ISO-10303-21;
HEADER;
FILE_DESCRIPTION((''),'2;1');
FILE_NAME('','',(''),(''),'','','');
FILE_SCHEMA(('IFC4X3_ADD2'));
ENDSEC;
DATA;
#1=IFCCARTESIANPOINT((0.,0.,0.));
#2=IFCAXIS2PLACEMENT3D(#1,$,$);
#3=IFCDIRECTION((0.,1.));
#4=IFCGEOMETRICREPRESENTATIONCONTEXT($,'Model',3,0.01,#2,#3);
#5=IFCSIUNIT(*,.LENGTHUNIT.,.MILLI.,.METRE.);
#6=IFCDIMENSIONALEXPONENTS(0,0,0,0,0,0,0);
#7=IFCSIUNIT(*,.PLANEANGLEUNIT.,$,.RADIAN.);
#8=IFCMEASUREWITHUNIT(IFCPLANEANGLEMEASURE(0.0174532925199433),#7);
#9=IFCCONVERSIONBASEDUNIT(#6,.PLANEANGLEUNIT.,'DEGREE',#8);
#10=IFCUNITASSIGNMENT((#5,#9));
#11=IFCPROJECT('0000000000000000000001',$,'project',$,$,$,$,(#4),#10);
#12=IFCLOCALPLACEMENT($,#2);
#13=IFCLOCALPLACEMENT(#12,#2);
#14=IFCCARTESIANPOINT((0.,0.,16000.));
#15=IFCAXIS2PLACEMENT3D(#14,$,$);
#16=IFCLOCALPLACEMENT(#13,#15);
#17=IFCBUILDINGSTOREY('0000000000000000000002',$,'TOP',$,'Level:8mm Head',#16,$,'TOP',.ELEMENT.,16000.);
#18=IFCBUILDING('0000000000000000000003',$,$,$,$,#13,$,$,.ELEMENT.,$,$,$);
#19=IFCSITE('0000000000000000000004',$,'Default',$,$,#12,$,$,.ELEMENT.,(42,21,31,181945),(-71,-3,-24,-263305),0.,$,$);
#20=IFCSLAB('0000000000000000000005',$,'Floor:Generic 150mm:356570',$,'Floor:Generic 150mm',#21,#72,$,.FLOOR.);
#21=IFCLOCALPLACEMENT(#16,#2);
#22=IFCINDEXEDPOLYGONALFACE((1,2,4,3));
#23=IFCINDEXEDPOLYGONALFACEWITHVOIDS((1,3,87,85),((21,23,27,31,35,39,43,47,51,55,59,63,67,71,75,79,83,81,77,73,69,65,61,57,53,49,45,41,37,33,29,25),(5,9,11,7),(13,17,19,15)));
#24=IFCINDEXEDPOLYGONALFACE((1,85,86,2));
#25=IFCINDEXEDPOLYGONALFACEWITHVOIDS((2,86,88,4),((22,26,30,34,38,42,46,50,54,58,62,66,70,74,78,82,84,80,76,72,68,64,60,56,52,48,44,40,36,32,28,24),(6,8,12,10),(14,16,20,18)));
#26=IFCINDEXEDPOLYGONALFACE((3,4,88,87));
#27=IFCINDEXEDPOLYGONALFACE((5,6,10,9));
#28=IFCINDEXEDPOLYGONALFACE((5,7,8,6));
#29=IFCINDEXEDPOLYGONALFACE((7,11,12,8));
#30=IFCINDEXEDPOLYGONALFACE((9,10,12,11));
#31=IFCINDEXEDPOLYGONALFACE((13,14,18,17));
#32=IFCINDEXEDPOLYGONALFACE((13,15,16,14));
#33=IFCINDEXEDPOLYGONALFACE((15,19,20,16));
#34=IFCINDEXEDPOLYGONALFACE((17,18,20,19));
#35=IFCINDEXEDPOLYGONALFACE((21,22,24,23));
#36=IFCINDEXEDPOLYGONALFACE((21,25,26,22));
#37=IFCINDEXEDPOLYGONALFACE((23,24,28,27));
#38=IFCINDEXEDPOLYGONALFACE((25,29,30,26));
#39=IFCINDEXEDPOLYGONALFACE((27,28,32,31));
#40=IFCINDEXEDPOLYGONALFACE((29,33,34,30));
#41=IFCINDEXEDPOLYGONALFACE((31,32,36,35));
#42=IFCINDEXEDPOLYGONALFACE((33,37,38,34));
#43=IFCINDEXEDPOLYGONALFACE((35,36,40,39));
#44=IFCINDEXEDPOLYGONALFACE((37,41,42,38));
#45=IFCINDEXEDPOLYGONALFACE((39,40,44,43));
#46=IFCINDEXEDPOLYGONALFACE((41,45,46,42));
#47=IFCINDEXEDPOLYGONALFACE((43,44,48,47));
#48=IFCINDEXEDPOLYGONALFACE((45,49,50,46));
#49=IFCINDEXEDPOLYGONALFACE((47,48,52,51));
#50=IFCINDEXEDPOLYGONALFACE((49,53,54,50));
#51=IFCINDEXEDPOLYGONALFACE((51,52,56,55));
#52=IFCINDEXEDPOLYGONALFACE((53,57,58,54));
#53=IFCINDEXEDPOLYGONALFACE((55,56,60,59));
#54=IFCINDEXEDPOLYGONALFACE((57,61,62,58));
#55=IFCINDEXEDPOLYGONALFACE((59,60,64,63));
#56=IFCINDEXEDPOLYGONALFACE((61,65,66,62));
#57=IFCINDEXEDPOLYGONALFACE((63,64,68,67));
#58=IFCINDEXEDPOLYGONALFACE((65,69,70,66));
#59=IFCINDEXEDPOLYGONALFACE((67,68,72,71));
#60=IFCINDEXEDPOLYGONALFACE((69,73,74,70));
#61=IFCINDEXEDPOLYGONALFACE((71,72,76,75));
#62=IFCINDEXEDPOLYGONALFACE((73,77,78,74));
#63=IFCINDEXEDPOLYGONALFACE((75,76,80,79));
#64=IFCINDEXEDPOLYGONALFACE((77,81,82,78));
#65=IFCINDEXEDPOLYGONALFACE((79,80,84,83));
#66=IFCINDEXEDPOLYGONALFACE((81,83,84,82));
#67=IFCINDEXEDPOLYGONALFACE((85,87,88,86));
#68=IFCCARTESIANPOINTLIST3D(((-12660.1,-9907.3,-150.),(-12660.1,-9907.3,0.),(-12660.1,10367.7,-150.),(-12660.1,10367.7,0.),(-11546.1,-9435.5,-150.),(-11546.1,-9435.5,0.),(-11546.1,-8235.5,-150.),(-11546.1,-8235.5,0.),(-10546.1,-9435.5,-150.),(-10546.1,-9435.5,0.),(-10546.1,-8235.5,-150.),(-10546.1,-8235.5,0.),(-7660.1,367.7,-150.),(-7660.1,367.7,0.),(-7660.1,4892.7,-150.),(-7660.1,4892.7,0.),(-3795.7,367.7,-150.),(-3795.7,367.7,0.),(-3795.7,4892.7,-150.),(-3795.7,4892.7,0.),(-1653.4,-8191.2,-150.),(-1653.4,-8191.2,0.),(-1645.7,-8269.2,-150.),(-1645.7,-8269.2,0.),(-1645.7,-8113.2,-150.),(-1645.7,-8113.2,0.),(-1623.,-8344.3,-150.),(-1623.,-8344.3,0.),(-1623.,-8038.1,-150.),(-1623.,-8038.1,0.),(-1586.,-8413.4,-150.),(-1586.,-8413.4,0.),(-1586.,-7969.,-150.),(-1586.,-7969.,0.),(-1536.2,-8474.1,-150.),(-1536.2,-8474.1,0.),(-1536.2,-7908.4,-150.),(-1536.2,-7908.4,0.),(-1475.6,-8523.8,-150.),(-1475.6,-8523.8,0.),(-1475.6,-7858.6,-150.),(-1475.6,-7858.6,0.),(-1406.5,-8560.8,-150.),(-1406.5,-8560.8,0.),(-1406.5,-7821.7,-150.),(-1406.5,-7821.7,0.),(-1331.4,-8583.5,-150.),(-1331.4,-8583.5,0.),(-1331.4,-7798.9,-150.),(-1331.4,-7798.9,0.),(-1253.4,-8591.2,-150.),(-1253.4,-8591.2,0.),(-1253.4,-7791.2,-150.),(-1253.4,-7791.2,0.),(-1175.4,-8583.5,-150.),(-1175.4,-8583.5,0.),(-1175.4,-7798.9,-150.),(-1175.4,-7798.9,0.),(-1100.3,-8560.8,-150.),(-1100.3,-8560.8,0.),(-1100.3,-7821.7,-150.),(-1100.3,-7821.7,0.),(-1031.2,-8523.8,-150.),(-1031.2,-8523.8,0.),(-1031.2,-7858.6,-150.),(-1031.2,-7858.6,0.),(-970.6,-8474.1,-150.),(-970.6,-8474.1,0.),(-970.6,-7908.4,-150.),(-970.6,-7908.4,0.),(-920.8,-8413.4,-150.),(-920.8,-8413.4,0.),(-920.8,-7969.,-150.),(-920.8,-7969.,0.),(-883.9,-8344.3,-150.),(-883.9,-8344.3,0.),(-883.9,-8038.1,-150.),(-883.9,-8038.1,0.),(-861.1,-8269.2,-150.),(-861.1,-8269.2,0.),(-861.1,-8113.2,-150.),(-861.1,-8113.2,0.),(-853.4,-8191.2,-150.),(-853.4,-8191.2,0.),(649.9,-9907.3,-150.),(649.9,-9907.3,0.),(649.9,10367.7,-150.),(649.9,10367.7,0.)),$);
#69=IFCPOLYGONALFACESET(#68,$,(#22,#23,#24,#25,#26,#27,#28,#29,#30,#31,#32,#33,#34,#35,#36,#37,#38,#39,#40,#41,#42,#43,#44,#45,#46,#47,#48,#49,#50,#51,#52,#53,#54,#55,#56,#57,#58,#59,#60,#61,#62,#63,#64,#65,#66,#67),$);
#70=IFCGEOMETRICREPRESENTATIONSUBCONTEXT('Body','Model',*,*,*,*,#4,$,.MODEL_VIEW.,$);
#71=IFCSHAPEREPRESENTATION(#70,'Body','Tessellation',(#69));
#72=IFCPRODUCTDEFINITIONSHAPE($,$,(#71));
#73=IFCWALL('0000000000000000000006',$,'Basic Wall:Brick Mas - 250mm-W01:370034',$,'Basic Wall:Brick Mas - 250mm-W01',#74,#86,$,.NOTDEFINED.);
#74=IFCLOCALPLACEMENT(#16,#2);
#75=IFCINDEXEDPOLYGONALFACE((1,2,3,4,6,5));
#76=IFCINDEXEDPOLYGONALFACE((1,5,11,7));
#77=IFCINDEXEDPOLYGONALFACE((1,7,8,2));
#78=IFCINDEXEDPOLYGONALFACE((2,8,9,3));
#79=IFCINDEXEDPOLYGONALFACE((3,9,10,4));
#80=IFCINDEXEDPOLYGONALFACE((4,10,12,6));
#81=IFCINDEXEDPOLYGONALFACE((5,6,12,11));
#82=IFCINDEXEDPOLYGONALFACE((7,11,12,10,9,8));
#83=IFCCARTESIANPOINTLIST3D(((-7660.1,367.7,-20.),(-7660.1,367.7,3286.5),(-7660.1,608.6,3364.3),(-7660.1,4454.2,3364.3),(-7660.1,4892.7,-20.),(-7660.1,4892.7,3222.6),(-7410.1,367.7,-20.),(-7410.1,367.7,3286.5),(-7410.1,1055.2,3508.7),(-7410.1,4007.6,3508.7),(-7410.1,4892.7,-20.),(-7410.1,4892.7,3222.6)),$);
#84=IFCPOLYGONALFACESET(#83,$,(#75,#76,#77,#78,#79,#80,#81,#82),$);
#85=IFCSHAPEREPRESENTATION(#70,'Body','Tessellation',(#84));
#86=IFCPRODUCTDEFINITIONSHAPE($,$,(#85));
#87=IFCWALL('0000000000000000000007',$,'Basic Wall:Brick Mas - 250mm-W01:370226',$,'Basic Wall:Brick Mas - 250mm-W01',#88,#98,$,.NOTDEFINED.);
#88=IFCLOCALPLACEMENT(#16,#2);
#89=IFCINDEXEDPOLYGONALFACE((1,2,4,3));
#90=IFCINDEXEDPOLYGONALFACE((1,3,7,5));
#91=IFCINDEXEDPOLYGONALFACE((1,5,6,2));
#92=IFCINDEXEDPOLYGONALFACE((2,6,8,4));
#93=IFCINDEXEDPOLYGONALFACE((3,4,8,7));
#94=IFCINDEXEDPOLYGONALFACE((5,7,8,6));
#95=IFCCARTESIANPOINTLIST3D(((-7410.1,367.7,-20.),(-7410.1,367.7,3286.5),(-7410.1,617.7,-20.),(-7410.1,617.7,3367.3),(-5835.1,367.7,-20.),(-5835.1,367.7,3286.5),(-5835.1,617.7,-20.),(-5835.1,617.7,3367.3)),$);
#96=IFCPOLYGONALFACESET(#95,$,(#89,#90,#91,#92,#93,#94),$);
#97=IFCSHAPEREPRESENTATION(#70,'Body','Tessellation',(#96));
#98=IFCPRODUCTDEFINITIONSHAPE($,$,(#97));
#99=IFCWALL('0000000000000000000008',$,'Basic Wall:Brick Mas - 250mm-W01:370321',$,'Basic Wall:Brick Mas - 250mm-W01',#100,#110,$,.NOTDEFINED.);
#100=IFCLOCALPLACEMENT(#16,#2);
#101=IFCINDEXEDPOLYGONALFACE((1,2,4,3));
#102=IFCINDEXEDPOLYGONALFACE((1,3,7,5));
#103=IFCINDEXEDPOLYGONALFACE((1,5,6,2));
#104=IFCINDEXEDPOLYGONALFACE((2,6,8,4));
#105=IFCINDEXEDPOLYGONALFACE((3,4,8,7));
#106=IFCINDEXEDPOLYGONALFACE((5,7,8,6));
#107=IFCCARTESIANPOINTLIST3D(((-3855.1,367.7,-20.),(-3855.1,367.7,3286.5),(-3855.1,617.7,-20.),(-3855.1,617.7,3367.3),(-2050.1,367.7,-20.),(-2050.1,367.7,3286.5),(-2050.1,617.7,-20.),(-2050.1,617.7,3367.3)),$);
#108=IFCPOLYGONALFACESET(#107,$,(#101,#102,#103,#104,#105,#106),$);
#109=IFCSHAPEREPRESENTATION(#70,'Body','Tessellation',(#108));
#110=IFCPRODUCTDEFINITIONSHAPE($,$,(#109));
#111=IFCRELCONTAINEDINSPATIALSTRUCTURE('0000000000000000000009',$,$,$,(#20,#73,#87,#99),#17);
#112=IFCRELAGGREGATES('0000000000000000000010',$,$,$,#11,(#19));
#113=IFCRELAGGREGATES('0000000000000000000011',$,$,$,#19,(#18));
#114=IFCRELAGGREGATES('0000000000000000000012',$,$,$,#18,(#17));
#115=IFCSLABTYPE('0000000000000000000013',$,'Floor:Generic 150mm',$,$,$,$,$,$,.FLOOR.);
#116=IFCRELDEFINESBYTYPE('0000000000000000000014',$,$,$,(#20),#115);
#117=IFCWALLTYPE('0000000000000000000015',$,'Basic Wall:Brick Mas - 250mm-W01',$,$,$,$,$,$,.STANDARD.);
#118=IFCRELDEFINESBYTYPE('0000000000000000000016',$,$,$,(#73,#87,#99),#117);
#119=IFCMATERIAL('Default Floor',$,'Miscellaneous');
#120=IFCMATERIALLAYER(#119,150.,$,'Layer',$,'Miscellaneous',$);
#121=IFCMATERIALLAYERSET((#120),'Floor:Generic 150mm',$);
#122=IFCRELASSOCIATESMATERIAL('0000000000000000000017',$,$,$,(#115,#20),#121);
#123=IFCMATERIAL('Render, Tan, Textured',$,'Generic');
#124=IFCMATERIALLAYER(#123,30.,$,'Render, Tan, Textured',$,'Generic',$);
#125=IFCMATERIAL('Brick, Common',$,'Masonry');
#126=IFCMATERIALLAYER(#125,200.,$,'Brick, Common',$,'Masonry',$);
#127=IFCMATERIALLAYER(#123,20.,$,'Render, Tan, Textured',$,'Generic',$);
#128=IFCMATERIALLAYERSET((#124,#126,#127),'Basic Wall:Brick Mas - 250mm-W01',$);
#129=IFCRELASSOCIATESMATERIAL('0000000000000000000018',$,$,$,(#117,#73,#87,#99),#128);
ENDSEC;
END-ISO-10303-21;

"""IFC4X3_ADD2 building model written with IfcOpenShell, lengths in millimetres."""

from ifc_helpers import new_model, entity, si_unit, converted_unit, direction, frame, frame_2d, origin, place, context, subcontext, project, spatial, polyline, rectangle, circle, extrude, clip, bounded_halfspace, material, layer, layer_set, layer_usage, type_object, element, save


model = new_model("IFC4X3_ADD2")

# Units and contexts
model_context = context("Model", 3, precision=0.01, world=origin(), true_north=direction((0.0, 1.0)))
body_context = subcontext(model_context, "Body", "Model", "MODEL_VIEW")
ifc_project = project(units=[si_unit("LENGTHUNIT", "METRE", prefix="MILLI"), converted_unit("PLANEANGLEUNIT", "DEGREE", entity("IfcPlaneAngleMeasure", 0.0174532925199433), si_unit("PLANEANGLEUNIT", "RADIAN"), dimensions=[0, 0, 0, 0, 0, 0, 0])], contexts=[model_context])

# Site, building, storey
site_placement = place(None, origin())
site = spatial("IfcSite", under=ifc_project, at=site_placement, Name="Default", CompositionType="ELEMENT", RefLatitude=(42, 21, 31, 181945), RefLongitude=(-71, -3, -24, -263305), RefElevation=0.0)
building_placement = place(site_placement, origin())
building = spatial("IfcBuilding", under=site, at=building_placement, CompositionType="ELEMENT")
storey_placement = place(building_placement, frame((0.0, 0.0, 16000.0)))
storey = spatial("IfcBuildingStorey", under=building, at=storey_placement, Name="TOP", ObjectType="Level:8mm Head", LongName="TOP", CompositionType="ELEMENT", Elevation=16000.0)

# Slab, openings
ifc_material_1 = material(Name="Default Floor", Category="Miscellaneous")
ifc_layer_1 = layer(ifc_material_1, 150.0, Name="Layer", Category="Miscellaneous")
ifc_layer_set_1 = layer_set([ifc_layer_1], Name="Floor:Generic 150mm")
ifc_layer_usage = layer_usage(ifc_layer_set_1, "AXIS3", "POSITIVE", 0.0)
slab_type = type_object("IfcSlabType", Name="Floor:Generic 150mm", PredefinedType="FLOOR", material=ifc_layer_set_1)
slab_placement = place(storey_placement, frame((-12660.1, -9907.3, -150.0)))
slab = element("IfcSlab", 1, at=slab_placement, inside=storey, type_object=slab_type, material=ifc_layer_usage, Name="Floor:Generic 150mm:356570", ObjectType="Floor:Generic 150mm", PredefinedType="FLOOR", context=body_context, shape_type="SweptSolid", body=[
    extrude(rectangle(XDim=20275.0, YDim=13310.0, at=frame_2d((0.0, 0.0), x_axis=(0.0, -1.0))), frame((6655.0, 10137.5, 150.0), z_axis=(0.0, 0.0, -1.0), x_axis=(-1.0, 0.0, 0.0)), (0.0, 0.0, 1.0), 150.0),
])
opening_1_placement = place(slab_placement, origin())
element("IfcOpeningElement", 2, at=opening_1_placement, cuts=slab, PredefinedType="OPENING", context=body_context, shape_type="SweptSolid", body=[
    extrude(circle(Radius=400.0, at=frame_2d((0.0, 0.0), x_axis=(1.0, 0.0))), frame((11406.7, 1716.1, 0.0)), (0.0, 0.0, 1.0), 150.0),
])
opening_2_placement = place(slab_placement, origin())
element("IfcOpeningElement", 3, at=opening_2_placement, cuts=slab, PredefinedType="OPENING", context=body_context, shape_type="SweptSolid", body=[
    extrude(rectangle(XDim=3864.4, YDim=4525.0, at=frame_2d((0.0, 0.0), x_axis=(1.0, 0.0))), frame((6932.2, 12537.5, 150.0), z_axis=(0.0, 0.0, -1.0), x_axis=(-1.0, 0.0, 0.0)), (0.0, 0.0, 1.0), 150.0),
])
opening_3_placement = place(slab_placement, origin())
element("IfcOpeningElement", 4, at=opening_3_placement, cuts=slab, PredefinedType="OPENING", context=body_context, shape_type="SweptSolid", body=[
    extrude(rectangle(XDim=1000.0, YDim=1200.0, at=frame_2d((0.0, 0.0), x_axis=(1.0, 0.0))), frame((1613.9, 1071.8, 150.0), z_axis=(0.0, 0.0, -1.0), x_axis=(-1.0, 0.0, 0.0)), (0.0, 0.0, 1.0), 150.0),
])

# Walls
ifc_material_2 = material(Name="Render, Tan, Textured", Category="Generic")
ifc_layer_2 = layer(ifc_material_2, 30.0, Name="Render, Tan, Textured", Category="Generic")
ifc_material_3 = material(Name="Brick, Common", Category="Masonry")
ifc_layer_3 = layer(ifc_material_3, 200.0, Name="Brick, Common", Category="Masonry")
ifc_layer_4 = layer(ifc_material_2, 20.0, Name="Render, Tan, Textured", Category="Generic")
ifc_layer_set_2 = layer_set([ifc_layer_2, ifc_layer_3, ifc_layer_4], Name="Basic Wall:Brick Mas - 250mm-W01")
wall_type = type_object("IfcWallType", Name="Basic Wall:Brick Mas - 250mm-W01", PredefinedType="STANDARD", material=ifc_layer_set_2)
wall_1_placement = place(storey_placement, frame((-7535.1, 367.7, -20.0), z_axis=(0.0, 0.0, 1.0), x_axis=(0.0, 1.0, 0.0)))
element("IfcWall", 5, at=wall_1_placement, inside=storey, type_object=wall_type, material=ifc_layer_set_2, Name="Basic Wall:Brick Mas - 250mm-W01:370034", ObjectType="Basic Wall:Brick Mas - 250mm-W01", PredefinedType="NOTDEFINED", context=body_context, shape_type="Clipping", body=[
    clip(clip(clip(extrude(rectangle(XDim=4525.0, YDim=250.0, at=frame_2d((2262.5, 0.0), x_axis=(-1.0, 0.0))), origin(), (0.0, 0.0, 1.0), 3528.7), bounded_halfspace(frame((3639.9, -125.0, 3528.7), z_axis=(0.307548, 0.0, 0.951533), x_axis=(0.0, 1.0, 0.0)), False, frame((3639.9, -125.0, 3528.7)), polyline([(0.0, 0.0), (885.1, 0.0), (885.1, 250.0), (446.6, 250.0), (0.0, 0.0)]))), bounded_halfspace(frame((687.5, -125.0, 3528.7), z_axis=(0.0, 0.5, 0.866025), x_axis=(-1.0, 0.0, 0.0)), False, frame((687.5, -125.0, 3528.7)), polyline([(0.0, 0.0), (2952.4, 0.0), (3399.0, 250.0), (-446.6, 250.0), (0.0, 0.0)]))), bounded_halfspace(frame((0.0, -125.0, 3306.5), z_axis=(-0.307548, 0.0, 0.951533), x_axis=(0.0, -1.0, 0.0)), False, frame((0.0, -125.0, 3306.5)), polyline([(0.0, 0.0), (250.0, 0.0), (687.5, 0.0), (240.9, 250.0), (0.0, 250.0), (0.0, 0.0)]))),
])
wall_2_placement = place(storey_placement, frame((-7410.1, 492.7, -20.0)))
element("IfcWall", 6, at=wall_2_placement, inside=storey, type_object=wall_type, material=ifc_layer_set_2, Name="Basic Wall:Brick Mas - 250mm-W01:370226", ObjectType="Basic Wall:Brick Mas - 250mm-W01", PredefinedType="NOTDEFINED", context=body_context, shape_type="Clipping", body=[
    clip(extrude(rectangle(XDim=1575.0, YDim=250.0, at=frame_2d((787.5, 0.0), x_axis=(-1.0, 0.0))), origin(), (0.0, 0.0, 1.0), 3387.3), bounded_halfspace(frame((0.0, -125.0, 3306.5), z_axis=(0.0, -0.307548, 0.951533), x_axis=(1.0, 0.0, 0.0)), False, frame((0.0, -125.0, 3306.5)), polyline([(0.0, 0.0), (1575.0, 0.0), (1575.0, 250.0), (0.0, 250.0), (0.0, 0.0)]))),
])
wall_3_placement = place(storey_placement, frame((-3855.1, 492.7, -20.0)))
element("IfcWall", 7, at=wall_3_placement, inside=storey, type_object=wall_type, material=ifc_layer_set_2, Name="Basic Wall:Brick Mas - 250mm-W01:370321", ObjectType="Basic Wall:Brick Mas - 250mm-W01", PredefinedType="NOTDEFINED", context=body_context, shape_type="Clipping", body=[
    clip(extrude(rectangle(XDim=1805.0, YDim=250.0, at=frame_2d((902.5, 0.0), x_axis=(-1.0, 0.0))), origin(), (0.0, 0.0, 1.0), 3387.3), bounded_halfspace(frame((0.0, -125.0, 3306.5), z_axis=(0.0, -0.307548, 0.951533), x_axis=(1.0, 0.0, 0.0)), False, frame((0.0, -125.0, 3306.5)), polyline([(0.0, 0.0), (1805.0, 0.0), (1805.0, 250.0), (0.0, 250.0), (0.0, 0.0)]))),
])

save(model, "model.ifc")
